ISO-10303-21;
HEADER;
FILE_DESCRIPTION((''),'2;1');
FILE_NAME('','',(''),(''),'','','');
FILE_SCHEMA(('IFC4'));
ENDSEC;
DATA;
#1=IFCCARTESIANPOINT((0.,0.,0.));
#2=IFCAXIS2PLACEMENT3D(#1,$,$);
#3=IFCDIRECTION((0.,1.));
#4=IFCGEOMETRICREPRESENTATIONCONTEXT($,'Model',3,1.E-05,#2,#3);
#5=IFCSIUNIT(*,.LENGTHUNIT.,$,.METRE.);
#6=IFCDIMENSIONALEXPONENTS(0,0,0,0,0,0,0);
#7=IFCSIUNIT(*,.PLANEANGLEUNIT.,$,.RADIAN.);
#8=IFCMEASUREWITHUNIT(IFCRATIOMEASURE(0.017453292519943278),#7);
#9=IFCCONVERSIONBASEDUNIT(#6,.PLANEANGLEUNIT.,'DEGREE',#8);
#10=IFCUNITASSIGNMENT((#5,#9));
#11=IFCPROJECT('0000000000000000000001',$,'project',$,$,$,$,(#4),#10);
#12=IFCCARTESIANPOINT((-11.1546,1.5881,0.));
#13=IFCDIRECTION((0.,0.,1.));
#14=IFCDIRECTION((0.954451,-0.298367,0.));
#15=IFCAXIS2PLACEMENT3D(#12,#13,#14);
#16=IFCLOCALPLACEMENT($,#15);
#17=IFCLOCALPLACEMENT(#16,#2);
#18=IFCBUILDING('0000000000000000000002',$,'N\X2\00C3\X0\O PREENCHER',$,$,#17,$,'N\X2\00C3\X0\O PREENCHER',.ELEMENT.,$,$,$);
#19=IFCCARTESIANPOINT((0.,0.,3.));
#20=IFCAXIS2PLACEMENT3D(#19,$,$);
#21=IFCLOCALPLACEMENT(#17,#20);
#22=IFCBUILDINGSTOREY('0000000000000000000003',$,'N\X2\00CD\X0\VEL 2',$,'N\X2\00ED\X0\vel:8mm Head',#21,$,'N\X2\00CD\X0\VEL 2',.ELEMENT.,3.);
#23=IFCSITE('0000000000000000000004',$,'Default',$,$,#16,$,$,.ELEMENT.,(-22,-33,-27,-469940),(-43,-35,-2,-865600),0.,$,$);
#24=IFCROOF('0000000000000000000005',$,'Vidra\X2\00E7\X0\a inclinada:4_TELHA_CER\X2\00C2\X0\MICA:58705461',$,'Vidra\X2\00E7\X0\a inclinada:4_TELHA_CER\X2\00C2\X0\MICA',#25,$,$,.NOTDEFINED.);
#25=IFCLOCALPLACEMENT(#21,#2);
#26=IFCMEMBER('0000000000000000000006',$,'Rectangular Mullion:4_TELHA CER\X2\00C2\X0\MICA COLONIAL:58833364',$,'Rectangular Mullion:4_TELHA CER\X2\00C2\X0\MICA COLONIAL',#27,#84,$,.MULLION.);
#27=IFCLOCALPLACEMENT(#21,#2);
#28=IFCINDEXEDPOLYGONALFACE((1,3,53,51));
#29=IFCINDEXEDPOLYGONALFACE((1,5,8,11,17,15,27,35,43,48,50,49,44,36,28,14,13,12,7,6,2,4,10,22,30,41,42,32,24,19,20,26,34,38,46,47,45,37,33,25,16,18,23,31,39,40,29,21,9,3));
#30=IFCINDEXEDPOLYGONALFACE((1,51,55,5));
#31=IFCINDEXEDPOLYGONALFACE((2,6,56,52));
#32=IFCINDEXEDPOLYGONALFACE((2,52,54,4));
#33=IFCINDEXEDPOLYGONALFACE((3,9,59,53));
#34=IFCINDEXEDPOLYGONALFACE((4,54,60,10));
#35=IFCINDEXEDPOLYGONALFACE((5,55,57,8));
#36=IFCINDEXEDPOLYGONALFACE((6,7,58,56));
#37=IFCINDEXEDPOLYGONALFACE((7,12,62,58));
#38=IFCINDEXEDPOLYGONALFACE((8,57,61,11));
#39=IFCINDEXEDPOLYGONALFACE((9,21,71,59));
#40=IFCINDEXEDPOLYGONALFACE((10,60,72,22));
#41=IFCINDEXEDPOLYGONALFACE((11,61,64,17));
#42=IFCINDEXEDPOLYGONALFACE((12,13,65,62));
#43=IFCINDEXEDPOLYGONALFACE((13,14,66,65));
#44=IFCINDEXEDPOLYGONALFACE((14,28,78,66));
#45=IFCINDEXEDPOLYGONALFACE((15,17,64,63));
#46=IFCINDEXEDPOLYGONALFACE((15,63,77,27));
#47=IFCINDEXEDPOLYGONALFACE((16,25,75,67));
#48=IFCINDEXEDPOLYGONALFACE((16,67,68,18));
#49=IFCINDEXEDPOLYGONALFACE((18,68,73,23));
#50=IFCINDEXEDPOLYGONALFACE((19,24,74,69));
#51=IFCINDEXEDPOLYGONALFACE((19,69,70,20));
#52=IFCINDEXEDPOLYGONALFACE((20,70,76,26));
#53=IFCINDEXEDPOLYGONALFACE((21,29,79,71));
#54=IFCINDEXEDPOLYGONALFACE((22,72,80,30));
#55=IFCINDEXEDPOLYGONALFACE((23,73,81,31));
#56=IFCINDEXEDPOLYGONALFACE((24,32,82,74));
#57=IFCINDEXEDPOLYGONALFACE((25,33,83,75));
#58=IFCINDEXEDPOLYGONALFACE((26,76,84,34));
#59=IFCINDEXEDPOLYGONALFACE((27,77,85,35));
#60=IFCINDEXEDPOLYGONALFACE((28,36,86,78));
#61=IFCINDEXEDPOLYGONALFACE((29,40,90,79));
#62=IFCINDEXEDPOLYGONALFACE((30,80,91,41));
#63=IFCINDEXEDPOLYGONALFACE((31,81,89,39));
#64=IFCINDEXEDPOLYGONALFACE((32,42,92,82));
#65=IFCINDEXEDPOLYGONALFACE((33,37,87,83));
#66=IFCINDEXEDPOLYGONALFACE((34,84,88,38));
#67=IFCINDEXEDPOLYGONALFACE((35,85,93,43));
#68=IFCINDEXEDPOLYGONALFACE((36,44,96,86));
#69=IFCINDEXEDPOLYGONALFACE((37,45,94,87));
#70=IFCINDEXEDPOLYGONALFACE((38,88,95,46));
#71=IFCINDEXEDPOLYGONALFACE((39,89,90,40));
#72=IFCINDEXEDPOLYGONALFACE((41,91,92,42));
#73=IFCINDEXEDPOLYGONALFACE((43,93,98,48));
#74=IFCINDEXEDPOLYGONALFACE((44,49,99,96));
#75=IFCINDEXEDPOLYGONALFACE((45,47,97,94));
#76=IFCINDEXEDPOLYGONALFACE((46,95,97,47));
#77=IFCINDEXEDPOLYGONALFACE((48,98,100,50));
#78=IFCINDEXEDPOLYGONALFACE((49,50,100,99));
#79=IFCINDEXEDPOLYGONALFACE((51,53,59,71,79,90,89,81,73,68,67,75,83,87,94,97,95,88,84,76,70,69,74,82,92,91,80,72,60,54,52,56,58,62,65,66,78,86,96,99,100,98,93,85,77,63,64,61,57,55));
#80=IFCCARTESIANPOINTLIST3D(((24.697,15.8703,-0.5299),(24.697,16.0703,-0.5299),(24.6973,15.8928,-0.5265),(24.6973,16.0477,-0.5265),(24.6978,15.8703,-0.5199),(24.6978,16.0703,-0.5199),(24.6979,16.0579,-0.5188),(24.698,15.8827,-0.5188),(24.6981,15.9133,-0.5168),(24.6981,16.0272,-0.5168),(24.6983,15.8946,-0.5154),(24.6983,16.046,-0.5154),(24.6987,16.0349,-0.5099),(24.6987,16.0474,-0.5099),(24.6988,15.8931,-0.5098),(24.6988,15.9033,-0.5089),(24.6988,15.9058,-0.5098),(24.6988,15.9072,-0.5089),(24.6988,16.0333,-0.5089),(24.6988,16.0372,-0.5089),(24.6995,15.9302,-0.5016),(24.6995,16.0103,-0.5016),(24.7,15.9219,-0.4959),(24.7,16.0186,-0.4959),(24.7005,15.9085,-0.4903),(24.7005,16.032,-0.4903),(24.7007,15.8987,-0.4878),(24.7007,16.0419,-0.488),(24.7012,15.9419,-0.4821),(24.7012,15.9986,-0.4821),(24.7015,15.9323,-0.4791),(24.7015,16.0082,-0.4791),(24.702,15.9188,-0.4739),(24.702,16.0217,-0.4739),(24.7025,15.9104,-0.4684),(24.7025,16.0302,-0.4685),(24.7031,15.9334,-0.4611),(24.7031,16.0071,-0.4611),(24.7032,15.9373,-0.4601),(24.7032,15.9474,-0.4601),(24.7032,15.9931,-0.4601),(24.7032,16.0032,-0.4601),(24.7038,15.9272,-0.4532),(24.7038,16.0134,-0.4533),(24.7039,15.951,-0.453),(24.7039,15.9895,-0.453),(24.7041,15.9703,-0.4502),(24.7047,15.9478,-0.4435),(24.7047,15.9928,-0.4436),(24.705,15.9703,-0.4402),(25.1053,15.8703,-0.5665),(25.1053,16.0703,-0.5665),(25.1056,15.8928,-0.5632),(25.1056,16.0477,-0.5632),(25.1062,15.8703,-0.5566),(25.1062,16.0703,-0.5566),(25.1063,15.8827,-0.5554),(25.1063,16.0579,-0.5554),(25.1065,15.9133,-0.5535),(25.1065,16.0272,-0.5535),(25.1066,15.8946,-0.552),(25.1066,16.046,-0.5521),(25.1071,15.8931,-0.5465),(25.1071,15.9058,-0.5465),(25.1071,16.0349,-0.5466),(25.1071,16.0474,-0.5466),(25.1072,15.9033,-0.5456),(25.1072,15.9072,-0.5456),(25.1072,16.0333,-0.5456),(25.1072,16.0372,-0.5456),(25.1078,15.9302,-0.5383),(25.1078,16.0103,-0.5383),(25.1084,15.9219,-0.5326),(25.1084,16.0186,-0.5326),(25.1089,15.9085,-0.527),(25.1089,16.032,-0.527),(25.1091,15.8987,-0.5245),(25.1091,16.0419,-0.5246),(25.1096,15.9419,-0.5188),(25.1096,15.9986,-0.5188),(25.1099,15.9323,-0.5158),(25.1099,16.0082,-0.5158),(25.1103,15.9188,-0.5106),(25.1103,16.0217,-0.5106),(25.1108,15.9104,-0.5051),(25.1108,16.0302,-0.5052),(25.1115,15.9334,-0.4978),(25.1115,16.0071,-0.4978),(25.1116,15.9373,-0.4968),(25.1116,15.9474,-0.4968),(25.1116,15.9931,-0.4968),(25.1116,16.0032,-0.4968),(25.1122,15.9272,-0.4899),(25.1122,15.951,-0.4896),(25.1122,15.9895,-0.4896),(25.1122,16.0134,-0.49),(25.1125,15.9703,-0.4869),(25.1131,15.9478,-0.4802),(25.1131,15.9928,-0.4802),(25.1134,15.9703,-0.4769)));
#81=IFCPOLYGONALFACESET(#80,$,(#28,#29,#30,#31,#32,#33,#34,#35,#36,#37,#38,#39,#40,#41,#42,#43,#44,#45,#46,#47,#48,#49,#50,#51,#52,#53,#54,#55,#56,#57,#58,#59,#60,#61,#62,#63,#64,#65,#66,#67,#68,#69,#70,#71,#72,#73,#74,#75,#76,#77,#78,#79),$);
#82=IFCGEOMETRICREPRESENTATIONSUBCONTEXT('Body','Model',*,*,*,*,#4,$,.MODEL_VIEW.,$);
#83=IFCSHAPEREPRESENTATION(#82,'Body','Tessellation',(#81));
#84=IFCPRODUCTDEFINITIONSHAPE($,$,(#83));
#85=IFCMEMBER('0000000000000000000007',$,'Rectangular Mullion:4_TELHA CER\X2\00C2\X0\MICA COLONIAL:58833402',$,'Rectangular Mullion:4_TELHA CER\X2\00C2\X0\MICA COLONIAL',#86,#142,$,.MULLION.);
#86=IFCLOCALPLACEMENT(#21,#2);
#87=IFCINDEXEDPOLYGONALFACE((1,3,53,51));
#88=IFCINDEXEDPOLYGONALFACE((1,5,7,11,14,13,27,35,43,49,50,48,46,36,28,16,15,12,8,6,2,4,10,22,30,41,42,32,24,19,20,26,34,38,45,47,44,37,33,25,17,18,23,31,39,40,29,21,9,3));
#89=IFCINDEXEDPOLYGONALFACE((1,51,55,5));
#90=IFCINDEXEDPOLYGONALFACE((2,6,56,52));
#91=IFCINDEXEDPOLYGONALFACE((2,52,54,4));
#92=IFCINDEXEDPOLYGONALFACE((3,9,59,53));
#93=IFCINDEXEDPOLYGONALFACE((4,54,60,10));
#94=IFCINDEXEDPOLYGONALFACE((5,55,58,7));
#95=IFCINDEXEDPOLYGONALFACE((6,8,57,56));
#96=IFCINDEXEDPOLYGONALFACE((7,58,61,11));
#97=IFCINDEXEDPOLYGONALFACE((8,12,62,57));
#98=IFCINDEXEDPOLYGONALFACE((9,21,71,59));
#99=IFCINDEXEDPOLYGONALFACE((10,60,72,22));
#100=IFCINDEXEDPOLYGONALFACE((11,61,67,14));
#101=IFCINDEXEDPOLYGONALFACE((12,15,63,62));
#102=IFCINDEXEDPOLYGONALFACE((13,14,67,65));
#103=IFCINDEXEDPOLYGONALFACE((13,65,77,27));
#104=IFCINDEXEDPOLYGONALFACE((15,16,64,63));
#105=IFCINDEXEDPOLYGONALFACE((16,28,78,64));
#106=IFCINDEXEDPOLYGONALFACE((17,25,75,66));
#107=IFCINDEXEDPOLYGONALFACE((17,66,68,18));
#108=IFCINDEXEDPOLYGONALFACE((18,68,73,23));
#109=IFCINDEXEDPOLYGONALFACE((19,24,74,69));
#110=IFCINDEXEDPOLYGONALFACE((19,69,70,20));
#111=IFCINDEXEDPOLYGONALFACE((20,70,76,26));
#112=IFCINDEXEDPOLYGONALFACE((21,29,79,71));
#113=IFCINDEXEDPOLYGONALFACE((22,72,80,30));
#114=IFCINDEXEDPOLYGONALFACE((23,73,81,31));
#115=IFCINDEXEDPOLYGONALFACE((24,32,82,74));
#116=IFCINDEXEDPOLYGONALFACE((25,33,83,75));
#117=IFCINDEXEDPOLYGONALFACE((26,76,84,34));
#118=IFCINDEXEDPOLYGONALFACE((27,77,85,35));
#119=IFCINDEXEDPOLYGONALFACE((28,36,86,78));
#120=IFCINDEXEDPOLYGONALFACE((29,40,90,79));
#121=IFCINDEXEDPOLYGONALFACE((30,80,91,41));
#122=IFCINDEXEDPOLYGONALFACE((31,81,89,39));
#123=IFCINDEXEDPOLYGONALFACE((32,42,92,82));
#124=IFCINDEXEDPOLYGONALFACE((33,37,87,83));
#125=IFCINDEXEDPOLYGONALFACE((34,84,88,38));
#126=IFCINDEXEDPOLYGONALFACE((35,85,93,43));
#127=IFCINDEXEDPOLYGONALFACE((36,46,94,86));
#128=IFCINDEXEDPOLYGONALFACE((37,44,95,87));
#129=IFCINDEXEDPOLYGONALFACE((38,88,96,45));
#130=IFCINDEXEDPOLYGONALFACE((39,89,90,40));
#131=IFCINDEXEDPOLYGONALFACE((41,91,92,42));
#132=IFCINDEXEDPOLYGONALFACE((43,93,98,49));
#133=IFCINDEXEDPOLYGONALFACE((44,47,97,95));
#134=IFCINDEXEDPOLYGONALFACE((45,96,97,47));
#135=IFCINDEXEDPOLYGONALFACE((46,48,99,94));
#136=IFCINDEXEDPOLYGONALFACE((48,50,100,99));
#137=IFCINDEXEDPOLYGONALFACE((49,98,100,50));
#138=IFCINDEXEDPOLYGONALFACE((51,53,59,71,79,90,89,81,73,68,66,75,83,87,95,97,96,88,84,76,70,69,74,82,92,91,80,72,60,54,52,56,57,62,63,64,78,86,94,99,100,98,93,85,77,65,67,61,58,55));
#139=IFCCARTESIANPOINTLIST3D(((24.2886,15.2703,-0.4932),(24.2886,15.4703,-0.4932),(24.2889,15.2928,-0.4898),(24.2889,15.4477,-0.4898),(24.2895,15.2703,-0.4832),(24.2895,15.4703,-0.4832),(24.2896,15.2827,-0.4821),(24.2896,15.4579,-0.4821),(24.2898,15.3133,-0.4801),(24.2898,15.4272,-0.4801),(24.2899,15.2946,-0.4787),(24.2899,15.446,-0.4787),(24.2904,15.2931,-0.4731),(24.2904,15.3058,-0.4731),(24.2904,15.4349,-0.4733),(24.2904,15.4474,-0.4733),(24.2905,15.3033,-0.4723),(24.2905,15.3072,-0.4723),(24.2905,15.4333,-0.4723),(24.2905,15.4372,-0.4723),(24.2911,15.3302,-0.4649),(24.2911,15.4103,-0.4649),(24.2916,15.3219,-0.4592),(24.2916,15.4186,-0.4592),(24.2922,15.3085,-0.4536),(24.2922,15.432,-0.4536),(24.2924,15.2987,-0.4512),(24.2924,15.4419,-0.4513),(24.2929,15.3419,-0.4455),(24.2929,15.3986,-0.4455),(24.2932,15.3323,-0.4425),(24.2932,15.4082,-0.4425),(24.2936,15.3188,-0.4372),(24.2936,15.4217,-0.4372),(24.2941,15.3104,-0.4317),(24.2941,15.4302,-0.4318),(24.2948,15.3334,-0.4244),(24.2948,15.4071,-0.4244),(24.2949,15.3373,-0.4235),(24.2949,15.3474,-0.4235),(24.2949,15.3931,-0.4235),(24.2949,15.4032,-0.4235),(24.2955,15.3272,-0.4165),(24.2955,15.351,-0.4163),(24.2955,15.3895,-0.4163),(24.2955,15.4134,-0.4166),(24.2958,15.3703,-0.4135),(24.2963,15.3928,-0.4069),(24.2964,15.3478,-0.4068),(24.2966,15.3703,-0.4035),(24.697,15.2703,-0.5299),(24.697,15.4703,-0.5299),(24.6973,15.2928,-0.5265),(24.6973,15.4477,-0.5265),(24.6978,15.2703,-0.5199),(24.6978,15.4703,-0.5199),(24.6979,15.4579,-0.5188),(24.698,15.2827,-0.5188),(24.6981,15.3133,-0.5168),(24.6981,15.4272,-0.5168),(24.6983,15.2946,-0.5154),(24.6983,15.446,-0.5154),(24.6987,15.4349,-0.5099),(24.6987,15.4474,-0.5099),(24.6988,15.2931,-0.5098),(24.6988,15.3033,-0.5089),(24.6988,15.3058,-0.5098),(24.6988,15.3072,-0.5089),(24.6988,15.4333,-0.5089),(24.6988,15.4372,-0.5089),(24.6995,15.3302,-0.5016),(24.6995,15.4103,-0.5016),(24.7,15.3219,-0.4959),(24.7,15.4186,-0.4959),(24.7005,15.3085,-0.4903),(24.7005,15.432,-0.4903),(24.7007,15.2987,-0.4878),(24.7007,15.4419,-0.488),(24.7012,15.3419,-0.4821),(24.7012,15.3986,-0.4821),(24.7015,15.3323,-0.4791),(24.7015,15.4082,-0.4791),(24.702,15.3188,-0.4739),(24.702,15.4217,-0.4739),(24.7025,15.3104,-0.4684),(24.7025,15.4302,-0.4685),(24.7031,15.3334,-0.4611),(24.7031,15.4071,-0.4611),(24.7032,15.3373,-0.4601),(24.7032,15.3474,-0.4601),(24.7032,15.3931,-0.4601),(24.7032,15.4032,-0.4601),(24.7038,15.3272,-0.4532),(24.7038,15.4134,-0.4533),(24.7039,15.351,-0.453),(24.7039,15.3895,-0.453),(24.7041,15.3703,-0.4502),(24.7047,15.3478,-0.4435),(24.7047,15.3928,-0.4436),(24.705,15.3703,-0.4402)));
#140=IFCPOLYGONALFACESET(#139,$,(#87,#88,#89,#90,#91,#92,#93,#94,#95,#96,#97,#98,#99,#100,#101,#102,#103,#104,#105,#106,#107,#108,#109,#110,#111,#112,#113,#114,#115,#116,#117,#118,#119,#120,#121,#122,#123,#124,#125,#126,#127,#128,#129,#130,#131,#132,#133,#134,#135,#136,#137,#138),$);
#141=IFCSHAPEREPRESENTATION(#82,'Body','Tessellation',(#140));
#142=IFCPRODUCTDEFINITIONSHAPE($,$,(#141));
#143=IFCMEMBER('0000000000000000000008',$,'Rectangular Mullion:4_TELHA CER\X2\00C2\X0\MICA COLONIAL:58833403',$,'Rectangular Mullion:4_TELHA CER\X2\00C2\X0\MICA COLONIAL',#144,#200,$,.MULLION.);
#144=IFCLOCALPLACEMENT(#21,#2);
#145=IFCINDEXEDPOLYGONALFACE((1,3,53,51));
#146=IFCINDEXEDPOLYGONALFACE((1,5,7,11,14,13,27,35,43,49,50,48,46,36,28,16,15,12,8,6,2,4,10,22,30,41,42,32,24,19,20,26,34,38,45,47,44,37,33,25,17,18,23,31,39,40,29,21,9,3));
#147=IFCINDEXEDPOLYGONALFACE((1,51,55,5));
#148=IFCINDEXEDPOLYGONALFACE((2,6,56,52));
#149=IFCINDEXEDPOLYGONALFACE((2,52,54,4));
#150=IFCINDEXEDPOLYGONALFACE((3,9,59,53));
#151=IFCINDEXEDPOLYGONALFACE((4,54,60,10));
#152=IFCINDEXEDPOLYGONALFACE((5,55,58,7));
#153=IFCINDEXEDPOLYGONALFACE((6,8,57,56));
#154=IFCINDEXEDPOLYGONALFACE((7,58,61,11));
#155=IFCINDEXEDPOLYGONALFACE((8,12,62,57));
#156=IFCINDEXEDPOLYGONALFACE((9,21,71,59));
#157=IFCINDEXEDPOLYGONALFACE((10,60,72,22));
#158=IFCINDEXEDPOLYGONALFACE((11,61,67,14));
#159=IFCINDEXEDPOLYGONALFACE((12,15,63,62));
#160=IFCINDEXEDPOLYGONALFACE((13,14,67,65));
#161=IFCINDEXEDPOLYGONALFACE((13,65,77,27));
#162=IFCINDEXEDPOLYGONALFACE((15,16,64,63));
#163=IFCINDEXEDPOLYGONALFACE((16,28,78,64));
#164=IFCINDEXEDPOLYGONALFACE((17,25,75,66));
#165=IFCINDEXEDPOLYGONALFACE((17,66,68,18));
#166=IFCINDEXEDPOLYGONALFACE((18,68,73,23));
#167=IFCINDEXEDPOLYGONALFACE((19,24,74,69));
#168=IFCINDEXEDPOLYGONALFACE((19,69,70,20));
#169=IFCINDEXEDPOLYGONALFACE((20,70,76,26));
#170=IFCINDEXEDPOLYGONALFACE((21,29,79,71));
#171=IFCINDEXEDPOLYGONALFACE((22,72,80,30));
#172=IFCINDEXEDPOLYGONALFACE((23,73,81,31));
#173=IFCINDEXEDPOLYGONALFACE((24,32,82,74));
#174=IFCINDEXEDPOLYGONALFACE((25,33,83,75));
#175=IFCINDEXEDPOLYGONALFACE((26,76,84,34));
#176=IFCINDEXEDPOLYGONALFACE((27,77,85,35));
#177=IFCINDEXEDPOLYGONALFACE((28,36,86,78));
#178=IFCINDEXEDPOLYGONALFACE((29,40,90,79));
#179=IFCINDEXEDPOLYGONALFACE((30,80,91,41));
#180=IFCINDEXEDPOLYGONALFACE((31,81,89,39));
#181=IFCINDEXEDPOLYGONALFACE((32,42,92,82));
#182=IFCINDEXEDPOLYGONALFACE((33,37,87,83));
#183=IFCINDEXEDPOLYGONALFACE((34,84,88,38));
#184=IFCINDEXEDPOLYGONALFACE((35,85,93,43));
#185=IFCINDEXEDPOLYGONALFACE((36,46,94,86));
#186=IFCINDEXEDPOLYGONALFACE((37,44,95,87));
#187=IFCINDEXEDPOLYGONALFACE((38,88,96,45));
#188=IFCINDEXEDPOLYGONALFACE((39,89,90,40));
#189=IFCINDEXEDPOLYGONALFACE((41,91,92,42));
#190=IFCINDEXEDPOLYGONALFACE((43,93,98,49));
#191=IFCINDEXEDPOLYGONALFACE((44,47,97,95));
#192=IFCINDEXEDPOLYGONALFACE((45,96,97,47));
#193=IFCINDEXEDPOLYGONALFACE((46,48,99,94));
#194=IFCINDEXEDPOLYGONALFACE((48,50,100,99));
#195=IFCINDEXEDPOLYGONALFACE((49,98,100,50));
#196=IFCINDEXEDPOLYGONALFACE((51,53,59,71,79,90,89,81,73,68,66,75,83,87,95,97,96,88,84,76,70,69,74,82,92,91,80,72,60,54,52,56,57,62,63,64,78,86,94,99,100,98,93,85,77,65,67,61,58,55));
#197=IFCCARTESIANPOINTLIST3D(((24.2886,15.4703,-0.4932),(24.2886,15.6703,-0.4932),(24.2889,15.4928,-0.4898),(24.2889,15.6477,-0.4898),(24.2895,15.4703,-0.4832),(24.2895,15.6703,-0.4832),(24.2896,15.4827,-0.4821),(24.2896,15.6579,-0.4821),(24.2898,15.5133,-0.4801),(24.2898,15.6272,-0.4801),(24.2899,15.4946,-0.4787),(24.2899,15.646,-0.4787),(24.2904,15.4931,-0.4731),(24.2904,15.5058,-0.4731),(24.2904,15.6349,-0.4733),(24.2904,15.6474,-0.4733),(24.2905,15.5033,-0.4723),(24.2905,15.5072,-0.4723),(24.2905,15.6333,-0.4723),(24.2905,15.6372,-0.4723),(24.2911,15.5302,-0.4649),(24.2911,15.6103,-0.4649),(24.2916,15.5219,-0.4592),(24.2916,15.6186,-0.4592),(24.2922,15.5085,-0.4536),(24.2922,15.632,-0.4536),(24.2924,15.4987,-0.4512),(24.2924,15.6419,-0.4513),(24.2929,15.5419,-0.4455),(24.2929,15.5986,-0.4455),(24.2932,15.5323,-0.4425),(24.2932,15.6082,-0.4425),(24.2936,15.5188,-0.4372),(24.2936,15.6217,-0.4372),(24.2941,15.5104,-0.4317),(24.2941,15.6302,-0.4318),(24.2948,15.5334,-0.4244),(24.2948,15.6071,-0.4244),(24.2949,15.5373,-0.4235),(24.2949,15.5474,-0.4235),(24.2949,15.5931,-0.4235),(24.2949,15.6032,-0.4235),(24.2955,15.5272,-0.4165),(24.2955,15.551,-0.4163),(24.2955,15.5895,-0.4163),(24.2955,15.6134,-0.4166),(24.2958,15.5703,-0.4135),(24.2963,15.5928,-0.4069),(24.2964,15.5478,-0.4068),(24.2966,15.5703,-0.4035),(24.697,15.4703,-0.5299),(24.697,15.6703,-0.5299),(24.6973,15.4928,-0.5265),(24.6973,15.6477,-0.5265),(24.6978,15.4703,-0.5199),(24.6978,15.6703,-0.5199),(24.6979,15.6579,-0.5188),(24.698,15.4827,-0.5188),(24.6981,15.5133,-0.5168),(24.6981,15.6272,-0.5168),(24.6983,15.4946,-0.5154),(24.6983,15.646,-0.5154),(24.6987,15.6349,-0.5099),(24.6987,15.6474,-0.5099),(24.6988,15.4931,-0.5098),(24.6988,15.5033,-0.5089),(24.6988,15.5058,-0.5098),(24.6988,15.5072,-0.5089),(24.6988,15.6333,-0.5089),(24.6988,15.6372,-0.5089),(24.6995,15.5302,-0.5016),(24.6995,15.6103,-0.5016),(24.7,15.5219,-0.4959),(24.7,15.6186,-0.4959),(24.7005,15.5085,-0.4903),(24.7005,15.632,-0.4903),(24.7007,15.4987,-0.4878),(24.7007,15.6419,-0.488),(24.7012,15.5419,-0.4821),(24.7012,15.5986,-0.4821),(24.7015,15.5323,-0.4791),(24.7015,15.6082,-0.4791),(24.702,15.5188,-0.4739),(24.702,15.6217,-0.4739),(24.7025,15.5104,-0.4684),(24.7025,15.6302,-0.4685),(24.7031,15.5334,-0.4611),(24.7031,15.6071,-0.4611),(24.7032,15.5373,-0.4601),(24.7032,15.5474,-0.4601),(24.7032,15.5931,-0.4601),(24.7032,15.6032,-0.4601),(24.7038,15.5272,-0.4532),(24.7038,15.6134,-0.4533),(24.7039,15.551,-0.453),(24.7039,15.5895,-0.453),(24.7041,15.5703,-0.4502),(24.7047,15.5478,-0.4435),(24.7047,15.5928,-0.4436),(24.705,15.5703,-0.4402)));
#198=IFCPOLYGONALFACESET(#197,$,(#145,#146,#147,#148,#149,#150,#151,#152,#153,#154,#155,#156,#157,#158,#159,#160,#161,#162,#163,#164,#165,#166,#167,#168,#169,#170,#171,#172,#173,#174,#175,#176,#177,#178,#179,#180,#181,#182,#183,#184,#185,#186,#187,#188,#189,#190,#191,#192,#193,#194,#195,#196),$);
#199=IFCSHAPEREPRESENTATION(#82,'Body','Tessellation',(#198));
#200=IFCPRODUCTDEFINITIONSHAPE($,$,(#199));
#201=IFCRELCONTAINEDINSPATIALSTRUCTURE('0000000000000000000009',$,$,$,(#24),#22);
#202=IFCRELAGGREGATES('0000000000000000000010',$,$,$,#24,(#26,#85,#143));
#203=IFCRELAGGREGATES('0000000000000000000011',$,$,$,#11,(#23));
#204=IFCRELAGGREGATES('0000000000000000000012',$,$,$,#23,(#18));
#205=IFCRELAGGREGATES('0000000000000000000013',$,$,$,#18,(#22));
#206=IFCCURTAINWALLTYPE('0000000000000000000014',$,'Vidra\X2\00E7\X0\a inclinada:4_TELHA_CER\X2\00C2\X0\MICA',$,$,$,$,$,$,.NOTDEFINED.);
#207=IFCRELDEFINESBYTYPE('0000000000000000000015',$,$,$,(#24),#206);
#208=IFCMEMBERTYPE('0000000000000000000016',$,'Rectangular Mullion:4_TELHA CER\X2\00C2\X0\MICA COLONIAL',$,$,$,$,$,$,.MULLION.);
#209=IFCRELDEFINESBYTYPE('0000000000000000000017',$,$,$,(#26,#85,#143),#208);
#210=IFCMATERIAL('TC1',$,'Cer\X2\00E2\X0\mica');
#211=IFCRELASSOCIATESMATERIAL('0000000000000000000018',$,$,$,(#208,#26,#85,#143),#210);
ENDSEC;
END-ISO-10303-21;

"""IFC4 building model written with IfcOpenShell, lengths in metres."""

from ifc_helpers import new_model, entity, si_unit, converted_unit, direction, frame, origin, place, context, subcontext, project, spatial, line, arc, indexed_curve, outline, extrude, source, transform, mapped, material, type_object, type_shapes, element, aggregate, save


model = new_model("IFC4")

# Units and contexts
model_context = context("Model", 3, precision=1e-05, world=origin(), true_north=direction((0.0, 1.0)))
body_context = subcontext(model_context, "Body", "Model", "MODEL_VIEW")
ifc_project = project(units=[si_unit("LENGTHUNIT", "METRE"), converted_unit("PLANEANGLEUNIT", "DEGREE", entity("IfcRatioMeasure", 0.017453292519943278), si_unit("PLANEANGLEUNIT", "RADIAN"), dimensions=[0, 0, 0, 0, 0, 0, 0])], contexts=[model_context])

# Site, building, storey
site_placement = place(None, frame((-11.1546, 1.5881, 0.0), z_axis=(0.0, 0.0, 1.0), x_axis=(0.954451, -0.298367, 0.0)))
site = spatial("IfcSite", under=ifc_project, at=site_placement, Name="Default", CompositionType="ELEMENT", RefLatitude=(-22, -33, -27, -469940), RefLongitude=(-43, -35, -2, -865600), RefElevation=0.0)
building_placement = place(site_placement, origin())
building = spatial("IfcBuilding", under=site, at=building_placement, Name="NÃO PREENCHER", LongName="NÃO PREENCHER", CompositionType="ELEMENT")
storey_placement = place(building_placement, frame((0.0, 0.0, 3.0)))
storey = spatial("IfcBuildingStorey", under=building, at=storey_placement, Name="NÍVEL 2", ObjectType="Nível:8mm Head", LongName="NÍVEL 2", CompositionType="ELEMENT", Elevation=3.0)

# Roof, members
curtain_wall_type = type_object("IfcCurtainWallType", Name="Vidraça inclinada:4_TELHA_CERÂMICA", PredefinedType="NOTDEFINED")
roof_placement = place(storey_placement, frame((0.0, 0.0, -3.0)))
roof = element("IfcRoof", 1, at=roof_placement, inside=storey, type_object=curtain_wall_type, Name="Vidraça inclinada:4_TELHA_CERÂMICA:58705461", ObjectType="Vidraça inclinada:4_TELHA_CERÂMICA", PredefinedType="NOTDEFINED")
ifc_material_1 = material(Name="TC1", Category="Cerâmica")
member_type_1 = type_object("IfcMemberType", Name="Rectangular Mullion:4_TELHA CERÂMICA COLONIAL", PredefinedType="MULLION", material=ifc_material_1)
shared_shape_1 = source(origin(), body_context, "Body", "SweptSolid", [
    extrude(outline(indexed_curve([(-0.029, -0.1), (-0.019, -0.1), (-0.0164, -0.0815), (-0.0089, -0.0645), (-0.0089, -0.0771), (0.061, 0.0), (-0.009, 0.0771), (-0.009, 0.0646), (-0.0165, 0.0816), (-0.019, 0.1), (-0.029, 0.1), (-0.0089, 0.0479), (0.041, 0.0229), (0.041, 0.0329), (0.0131, 0.0425), (-0.008, 0.0631), (-0.008, 0.067), (0.051, 0.0), (-0.008, -0.067), (-0.008, -0.0631), (0.0131, -0.0425), (0.041, -0.0329), (0.041, -0.0229), (-0.0089, -0.0479)], segments=[line(1, 2), arc(2, 3, 4), line(4, 5), arc(5, 6, 7), line(7, 8), arc(8, 9, 10), line(10, 11), arc(11, 12, 13), line(13, 14), arc(14, 15, 16), line(16, 17), arc(17, 18, 19), line(19, 20), arc(20, 21, 22), line(22, 23), arc(23, 24, 1)], self_intersect=False)), frame((0.0, -0.029, -0.41), z_axis=(0.0, 0.0, 1.0), x_axis=(0.0, -1.0, 0.0)), (0.0, 0.0, 1.0), 0.41),
])
type_shapes(member_type_1, [shared_shape_1])
member_1_placement = place(roof_placement, frame((24.697, 15.9703, 2.4701), z_axis=(-0.99599, 0.0, 0.089469), x_axis=(0.0, 1.0, 0.0)))
member_1 = element("IfcMember", 2, at=member_1_placement, type_object=member_type_1, material=ifc_material_1, Name="Rectangular Mullion:4_TELHA CERÂMICA COLONIAL:58833364", ObjectType="Rectangular Mullion:4_TELHA CERÂMICA COLONIAL", PredefinedType="MULLION", context=body_context, shape_type="MappedRepresentation", body=[
    mapped(shared_shape_1, transform((0.0, 0.0, 0.0), scale=1.0)),
])
member_2_placement = place(roof_placement, frame((24.2886, 15.3703, 2.5068), z_axis=(-0.99599, 0.0, 0.089469), x_axis=(0.0, 1.0, 0.0)))
member_2 = element("IfcMember", 3, at=member_2_placement, type_object=member_type_1, material=ifc_material_1, Name="Rectangular Mullion:4_TELHA CERÂMICA COLONIAL:58833402", ObjectType="Rectangular Mullion:4_TELHA CERÂMICA COLONIAL", PredefinedType="MULLION", context=body_context, shape_type="MappedRepresentation", body=[
    mapped(shared_shape_1, transform((0.0, 0.0, 0.0), scale=1.0)),
])
member_3_placement = place(roof_placement, frame((24.2886, 15.5703, 2.5068), z_axis=(-0.99599, 0.0, 0.089469), x_axis=(0.0, 1.0, 0.0)))
member_3 = element("IfcMember", 4, at=member_3_placement, type_object=member_type_1, material=ifc_material_1, Name="Rectangular Mullion:4_TELHA CERÂMICA COLONIAL:58833403", ObjectType="Rectangular Mullion:4_TELHA CERÂMICA COLONIAL", PredefinedType="MULLION", context=body_context, shape_type="MappedRepresentation", body=[
    mapped(shared_shape_1, transform((0.0, 0.0, 0.0), scale=1.0)),
])
aggregate(roof, [member_1, member_2, member_3])

save(model, "model.ifc")
